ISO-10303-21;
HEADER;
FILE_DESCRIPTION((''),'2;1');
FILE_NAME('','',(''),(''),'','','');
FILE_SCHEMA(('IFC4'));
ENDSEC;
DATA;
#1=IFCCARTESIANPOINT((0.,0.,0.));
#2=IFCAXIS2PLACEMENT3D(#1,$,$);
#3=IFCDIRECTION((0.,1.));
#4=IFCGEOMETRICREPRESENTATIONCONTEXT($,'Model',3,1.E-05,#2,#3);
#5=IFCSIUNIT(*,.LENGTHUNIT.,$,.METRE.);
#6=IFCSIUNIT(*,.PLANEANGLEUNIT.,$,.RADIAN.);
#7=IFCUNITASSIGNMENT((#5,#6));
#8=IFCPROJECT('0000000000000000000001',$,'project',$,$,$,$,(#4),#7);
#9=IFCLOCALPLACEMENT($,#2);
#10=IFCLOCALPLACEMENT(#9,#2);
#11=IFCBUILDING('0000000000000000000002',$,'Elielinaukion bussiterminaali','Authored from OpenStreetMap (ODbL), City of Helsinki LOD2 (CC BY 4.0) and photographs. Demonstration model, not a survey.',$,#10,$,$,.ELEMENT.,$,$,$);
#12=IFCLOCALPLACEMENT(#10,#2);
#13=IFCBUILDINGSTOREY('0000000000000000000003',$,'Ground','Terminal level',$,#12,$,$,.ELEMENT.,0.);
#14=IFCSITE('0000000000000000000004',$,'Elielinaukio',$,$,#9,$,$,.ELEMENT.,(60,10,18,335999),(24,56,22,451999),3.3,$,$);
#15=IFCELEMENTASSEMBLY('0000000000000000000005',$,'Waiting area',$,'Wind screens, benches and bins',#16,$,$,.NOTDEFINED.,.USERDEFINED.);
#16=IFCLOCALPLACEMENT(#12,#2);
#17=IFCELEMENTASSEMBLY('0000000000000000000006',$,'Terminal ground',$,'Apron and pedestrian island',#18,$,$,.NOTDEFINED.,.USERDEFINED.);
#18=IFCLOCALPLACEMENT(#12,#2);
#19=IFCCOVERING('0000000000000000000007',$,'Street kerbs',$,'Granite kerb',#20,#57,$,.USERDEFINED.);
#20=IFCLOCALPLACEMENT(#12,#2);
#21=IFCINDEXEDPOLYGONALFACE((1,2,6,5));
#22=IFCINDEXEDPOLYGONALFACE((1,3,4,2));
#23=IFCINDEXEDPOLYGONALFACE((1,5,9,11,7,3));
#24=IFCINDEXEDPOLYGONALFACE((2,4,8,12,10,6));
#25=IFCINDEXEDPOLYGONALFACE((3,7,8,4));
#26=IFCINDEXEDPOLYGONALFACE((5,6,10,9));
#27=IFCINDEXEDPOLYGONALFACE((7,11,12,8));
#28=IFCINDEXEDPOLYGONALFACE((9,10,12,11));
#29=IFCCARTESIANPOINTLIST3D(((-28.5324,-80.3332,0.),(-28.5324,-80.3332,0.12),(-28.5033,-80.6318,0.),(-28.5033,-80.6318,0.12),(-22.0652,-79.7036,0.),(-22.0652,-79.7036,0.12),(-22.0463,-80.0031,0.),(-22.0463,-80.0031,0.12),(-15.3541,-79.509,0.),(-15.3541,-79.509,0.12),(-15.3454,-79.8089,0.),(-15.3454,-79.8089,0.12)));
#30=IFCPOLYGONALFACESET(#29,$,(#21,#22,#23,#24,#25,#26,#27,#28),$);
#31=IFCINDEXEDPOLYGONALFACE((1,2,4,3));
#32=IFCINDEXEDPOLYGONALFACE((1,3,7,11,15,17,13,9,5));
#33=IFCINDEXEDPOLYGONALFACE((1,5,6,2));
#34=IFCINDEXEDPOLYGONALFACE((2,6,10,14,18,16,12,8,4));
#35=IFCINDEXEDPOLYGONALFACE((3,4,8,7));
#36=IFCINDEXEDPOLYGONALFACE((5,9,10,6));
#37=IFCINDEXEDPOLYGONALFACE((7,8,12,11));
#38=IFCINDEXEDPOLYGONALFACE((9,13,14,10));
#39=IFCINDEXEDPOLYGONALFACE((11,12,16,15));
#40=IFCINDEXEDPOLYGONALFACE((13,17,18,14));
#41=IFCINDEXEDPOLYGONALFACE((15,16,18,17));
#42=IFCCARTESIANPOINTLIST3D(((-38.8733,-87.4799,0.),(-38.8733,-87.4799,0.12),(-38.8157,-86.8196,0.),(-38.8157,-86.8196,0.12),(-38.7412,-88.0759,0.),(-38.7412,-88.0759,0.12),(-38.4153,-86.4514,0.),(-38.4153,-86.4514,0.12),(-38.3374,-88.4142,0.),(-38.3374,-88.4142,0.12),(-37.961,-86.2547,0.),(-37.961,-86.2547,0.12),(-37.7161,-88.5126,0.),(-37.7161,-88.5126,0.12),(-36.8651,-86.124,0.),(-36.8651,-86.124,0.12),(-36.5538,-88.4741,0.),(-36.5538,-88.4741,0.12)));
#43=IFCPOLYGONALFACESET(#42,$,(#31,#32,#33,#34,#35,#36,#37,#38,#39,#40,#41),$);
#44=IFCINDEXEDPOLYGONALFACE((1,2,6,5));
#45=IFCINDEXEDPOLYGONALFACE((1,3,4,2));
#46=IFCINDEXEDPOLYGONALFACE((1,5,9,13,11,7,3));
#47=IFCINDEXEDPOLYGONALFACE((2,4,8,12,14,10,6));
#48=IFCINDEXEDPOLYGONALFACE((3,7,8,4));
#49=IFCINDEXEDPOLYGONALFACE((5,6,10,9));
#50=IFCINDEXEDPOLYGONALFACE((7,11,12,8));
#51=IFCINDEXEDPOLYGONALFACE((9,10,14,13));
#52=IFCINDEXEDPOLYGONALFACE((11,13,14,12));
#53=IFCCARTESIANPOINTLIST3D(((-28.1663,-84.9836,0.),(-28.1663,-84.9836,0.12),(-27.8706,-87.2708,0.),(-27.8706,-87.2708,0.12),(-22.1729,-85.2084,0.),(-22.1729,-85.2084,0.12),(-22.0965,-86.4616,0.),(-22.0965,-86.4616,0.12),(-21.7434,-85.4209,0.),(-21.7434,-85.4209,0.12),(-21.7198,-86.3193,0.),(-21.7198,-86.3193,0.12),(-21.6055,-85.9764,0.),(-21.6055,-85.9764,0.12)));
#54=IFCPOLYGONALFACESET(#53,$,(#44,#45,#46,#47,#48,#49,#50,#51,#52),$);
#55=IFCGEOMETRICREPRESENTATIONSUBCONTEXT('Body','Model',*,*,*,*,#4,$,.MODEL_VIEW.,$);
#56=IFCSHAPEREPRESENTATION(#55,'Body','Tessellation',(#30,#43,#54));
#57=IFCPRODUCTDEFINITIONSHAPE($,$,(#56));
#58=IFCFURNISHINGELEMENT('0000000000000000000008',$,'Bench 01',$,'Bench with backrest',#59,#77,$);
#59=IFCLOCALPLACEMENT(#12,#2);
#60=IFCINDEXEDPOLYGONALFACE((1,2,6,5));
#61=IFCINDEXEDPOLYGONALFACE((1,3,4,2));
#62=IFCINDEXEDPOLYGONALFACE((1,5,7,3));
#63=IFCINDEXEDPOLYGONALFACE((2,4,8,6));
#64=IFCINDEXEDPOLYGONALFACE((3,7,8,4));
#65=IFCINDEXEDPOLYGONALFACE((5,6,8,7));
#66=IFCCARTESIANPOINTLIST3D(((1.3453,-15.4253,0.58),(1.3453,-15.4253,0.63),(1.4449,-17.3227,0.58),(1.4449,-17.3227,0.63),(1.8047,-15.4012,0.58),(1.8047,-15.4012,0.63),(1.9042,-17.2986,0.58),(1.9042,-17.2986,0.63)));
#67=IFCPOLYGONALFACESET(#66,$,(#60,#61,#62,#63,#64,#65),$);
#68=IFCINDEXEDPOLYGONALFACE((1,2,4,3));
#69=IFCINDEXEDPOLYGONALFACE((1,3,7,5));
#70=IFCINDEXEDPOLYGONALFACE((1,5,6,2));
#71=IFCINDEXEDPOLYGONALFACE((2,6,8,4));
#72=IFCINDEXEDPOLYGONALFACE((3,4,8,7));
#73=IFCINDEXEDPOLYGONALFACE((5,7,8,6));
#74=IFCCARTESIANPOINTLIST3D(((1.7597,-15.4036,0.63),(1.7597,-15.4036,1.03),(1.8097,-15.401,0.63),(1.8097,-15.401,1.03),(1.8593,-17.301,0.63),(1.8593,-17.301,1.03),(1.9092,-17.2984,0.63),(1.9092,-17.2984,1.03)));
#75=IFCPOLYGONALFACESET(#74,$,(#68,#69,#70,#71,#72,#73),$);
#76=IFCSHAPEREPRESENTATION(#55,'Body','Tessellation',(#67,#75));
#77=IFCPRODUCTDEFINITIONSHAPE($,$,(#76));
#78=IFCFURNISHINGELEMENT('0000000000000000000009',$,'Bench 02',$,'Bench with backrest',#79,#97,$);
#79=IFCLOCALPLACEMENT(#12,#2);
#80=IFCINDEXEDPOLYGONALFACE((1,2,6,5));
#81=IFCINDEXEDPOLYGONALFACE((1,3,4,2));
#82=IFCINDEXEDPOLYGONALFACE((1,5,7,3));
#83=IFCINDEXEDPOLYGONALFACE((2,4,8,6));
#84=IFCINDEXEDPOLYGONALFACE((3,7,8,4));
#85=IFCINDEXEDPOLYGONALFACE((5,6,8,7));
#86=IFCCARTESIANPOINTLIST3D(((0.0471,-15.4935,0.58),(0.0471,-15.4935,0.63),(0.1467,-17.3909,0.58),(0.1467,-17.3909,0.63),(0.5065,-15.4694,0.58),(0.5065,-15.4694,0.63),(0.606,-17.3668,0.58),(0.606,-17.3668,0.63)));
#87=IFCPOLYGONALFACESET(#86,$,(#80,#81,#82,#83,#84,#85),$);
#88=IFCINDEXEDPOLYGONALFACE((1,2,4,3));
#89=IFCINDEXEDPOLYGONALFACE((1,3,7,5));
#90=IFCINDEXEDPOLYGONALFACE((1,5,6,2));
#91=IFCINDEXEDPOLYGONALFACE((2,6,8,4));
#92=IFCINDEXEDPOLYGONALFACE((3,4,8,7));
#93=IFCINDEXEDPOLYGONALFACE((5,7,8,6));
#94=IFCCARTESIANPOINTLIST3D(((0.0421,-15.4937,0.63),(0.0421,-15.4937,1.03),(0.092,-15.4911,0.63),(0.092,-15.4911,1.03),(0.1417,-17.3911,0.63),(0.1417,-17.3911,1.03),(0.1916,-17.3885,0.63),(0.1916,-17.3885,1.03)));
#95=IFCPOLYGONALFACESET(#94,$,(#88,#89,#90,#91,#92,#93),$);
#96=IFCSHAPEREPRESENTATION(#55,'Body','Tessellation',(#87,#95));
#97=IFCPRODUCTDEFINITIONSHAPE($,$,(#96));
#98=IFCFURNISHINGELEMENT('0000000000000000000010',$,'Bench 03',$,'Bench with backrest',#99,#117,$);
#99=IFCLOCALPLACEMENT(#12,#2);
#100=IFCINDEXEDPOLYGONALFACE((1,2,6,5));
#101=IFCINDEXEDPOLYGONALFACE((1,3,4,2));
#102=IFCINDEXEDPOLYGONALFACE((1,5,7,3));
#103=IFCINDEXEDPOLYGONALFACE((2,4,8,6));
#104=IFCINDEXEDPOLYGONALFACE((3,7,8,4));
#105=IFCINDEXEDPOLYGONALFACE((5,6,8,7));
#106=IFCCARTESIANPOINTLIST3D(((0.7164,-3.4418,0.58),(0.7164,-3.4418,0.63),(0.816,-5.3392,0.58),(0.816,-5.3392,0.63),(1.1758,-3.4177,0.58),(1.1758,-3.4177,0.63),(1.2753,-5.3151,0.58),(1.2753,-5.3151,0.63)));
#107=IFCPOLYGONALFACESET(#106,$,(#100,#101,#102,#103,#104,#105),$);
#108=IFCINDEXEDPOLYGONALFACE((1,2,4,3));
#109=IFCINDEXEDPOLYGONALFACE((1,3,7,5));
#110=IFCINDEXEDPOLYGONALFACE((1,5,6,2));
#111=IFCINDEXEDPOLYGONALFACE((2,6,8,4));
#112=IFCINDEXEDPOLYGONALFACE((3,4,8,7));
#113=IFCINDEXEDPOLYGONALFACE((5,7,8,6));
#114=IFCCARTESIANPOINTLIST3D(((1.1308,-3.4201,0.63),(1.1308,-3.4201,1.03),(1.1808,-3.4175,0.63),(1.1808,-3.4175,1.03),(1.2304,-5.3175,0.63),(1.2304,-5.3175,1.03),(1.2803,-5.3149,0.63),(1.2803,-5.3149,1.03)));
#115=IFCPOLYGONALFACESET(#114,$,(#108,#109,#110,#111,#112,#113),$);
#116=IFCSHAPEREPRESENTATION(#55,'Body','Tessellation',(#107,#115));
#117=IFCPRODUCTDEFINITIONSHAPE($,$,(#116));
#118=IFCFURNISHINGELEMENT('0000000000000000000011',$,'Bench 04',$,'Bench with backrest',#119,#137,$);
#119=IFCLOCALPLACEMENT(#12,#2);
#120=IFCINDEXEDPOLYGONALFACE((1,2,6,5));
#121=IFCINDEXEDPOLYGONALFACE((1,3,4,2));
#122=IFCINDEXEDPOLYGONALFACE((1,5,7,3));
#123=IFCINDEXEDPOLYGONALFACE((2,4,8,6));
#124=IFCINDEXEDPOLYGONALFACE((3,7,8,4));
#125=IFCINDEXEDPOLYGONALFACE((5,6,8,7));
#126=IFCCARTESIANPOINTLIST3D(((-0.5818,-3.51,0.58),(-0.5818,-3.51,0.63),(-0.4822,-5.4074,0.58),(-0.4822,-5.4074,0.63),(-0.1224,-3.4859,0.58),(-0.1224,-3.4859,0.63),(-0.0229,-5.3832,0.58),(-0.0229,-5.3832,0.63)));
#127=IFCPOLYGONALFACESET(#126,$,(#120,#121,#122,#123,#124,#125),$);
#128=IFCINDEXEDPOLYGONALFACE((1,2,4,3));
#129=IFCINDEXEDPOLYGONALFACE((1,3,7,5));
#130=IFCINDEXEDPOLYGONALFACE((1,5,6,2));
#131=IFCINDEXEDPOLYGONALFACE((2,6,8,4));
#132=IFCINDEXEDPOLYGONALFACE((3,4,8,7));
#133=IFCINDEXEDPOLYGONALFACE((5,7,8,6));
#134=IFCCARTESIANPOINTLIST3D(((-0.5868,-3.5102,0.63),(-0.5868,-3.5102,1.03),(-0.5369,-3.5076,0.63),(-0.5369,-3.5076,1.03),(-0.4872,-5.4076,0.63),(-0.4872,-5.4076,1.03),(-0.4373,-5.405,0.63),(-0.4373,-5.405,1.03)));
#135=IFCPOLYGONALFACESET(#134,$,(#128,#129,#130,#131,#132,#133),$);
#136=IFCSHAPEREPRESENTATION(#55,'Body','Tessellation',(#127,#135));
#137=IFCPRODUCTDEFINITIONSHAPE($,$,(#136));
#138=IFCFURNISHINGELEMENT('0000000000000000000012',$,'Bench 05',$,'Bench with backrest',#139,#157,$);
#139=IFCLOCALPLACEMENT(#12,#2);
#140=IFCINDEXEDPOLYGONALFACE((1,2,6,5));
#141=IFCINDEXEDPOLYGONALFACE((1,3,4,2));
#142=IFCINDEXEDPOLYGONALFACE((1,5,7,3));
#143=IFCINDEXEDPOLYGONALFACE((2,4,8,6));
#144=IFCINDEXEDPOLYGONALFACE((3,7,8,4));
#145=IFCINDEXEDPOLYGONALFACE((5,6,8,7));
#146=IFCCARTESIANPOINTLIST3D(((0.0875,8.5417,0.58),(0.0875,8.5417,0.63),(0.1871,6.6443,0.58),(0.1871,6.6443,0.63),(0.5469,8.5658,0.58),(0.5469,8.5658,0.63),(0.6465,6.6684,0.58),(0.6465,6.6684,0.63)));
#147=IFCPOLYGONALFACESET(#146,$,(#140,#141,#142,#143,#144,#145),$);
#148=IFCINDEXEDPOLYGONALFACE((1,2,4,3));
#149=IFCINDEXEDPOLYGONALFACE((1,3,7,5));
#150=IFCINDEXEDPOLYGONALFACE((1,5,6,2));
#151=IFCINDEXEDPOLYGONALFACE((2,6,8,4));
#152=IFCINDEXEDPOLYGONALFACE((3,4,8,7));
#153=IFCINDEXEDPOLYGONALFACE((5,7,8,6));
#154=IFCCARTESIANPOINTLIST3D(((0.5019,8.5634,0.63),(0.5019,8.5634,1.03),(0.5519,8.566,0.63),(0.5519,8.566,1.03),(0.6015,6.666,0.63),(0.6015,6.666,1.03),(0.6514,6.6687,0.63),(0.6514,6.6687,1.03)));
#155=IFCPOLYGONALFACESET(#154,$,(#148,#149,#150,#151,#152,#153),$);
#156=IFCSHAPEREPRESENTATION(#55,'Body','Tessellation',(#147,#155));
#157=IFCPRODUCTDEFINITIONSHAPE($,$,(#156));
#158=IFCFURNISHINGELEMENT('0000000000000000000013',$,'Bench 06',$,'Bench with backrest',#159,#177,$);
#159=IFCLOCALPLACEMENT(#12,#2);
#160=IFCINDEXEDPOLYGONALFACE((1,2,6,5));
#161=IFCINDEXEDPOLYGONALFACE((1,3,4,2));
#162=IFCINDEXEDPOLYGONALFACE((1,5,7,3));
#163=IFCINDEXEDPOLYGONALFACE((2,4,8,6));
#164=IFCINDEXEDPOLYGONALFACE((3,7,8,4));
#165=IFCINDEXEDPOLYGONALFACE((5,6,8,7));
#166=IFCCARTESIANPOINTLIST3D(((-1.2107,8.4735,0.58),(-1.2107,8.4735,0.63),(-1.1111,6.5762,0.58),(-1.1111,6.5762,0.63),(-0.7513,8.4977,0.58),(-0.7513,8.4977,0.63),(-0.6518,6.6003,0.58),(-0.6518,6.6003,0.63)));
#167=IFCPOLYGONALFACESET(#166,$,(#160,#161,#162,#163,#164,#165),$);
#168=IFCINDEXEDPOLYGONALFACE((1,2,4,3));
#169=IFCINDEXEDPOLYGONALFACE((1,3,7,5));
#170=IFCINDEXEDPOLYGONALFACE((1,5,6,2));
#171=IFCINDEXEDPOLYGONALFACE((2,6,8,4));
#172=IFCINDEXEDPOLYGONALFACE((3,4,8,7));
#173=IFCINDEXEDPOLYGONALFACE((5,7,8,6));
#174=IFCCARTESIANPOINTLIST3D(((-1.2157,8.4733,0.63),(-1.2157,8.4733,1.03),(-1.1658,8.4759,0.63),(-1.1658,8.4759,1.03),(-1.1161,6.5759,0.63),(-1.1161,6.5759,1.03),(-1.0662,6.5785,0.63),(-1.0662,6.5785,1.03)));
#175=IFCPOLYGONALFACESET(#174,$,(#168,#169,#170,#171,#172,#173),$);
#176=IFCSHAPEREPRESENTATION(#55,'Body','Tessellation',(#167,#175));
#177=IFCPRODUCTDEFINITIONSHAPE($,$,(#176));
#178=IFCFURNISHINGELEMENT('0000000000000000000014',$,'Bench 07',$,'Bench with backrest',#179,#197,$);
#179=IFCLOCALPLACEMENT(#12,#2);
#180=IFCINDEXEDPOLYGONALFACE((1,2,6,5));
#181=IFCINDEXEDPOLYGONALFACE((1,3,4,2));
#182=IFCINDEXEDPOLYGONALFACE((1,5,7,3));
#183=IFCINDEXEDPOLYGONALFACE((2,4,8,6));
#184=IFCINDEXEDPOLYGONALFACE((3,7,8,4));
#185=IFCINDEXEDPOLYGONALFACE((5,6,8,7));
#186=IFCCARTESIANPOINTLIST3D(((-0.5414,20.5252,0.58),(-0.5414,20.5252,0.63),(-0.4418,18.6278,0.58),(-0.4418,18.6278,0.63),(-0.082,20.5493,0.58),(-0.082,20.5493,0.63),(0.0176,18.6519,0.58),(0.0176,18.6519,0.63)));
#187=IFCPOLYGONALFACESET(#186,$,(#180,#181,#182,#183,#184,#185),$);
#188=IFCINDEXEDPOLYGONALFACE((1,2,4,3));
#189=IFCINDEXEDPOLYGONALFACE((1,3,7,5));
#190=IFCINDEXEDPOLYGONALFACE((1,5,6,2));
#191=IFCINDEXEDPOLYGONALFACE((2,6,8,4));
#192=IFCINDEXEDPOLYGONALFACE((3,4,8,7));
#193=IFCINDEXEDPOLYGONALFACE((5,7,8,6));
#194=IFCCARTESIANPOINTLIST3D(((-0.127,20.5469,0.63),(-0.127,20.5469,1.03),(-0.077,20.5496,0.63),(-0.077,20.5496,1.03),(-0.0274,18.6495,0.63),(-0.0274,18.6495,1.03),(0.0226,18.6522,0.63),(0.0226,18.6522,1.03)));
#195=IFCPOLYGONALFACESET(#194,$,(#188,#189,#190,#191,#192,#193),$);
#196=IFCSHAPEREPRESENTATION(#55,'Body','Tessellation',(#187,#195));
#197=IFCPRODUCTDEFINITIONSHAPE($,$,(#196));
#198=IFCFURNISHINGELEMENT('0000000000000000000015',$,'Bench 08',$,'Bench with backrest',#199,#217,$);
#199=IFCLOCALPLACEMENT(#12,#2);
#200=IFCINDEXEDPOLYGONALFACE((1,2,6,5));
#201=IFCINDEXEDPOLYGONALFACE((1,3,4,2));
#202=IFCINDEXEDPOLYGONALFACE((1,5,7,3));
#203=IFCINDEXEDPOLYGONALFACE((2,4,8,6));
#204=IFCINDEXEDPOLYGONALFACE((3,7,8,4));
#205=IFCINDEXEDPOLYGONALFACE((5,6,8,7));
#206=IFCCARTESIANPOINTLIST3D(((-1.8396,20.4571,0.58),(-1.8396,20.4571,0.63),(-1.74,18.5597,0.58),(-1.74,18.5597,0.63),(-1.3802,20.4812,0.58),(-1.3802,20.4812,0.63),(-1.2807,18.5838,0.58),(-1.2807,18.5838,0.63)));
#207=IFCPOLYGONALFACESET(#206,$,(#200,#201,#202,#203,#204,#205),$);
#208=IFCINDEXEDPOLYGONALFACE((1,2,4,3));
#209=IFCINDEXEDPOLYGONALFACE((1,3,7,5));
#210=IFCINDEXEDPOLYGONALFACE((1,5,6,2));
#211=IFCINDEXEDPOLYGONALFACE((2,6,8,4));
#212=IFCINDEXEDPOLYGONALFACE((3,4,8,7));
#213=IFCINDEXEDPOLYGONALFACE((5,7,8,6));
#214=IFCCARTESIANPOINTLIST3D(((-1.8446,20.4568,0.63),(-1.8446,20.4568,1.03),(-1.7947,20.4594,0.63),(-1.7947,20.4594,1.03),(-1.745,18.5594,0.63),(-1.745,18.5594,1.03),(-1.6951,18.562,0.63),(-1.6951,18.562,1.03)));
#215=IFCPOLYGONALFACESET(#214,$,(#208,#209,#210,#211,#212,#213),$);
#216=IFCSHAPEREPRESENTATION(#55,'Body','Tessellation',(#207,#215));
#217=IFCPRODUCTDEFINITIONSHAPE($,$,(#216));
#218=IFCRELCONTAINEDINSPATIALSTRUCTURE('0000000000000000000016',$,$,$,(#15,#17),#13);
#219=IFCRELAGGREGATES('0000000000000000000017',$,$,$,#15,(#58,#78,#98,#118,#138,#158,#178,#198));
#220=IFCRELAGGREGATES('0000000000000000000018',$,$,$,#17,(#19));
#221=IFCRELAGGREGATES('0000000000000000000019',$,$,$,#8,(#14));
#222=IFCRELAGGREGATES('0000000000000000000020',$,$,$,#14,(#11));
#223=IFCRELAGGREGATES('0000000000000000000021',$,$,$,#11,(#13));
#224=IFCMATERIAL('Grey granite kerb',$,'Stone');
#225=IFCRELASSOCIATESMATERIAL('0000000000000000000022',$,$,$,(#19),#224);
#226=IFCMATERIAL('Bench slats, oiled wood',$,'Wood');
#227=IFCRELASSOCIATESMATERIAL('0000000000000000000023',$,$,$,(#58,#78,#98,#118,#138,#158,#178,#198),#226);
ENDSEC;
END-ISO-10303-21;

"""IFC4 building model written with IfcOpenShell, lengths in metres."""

from ifc_helpers import new_model, si_unit, direction, frame, frame_2d, origin, place, context, subcontext, project, spatial, polyline, rectangle, outline, extrude, material, element, aggregate, save


model = new_model("IFC4")

# Units and contexts
model_context = context("Model", 3, precision=1e-05, world=origin(), true_north=direction((0.0, 1.0)))
body_context = subcontext(model_context, "Body", "Model", "MODEL_VIEW")
ifc_project = project(units=[si_unit("LENGTHUNIT", "METRE"), si_unit("PLANEANGLEUNIT", "RADIAN")], contexts=[model_context])

# Site, building, storey
site_placement = place(None, origin())
site = spatial("IfcSite", under=ifc_project, at=site_placement, Name="Elielinaukio", CompositionType="ELEMENT", RefLatitude=(60, 10, 18, 335999), RefLongitude=(24, 56, 22, 451999), RefElevation=3.3)
building_placement = place(site_placement, origin())
building = spatial("IfcBuilding", under=site, at=building_placement, Name="Elielinaukion bussiterminaali", Description="Authored from OpenStreetMap (ODbL), City of Helsinki LOD2 (CC BY 4.0) and photographs. Demonstration model, not a survey.", CompositionType="ELEMENT")
storey_placement = place(building_placement, origin())
storey = spatial("IfcBuildingStorey", under=building, at=storey_placement, Name="Ground", Description="Terminal level", CompositionType="ELEMENT", Elevation=0.0)

# Element assembly
assembly_1_placement = place(building_placement, origin())
assembly_1 = element("IfcElementAssembly", 1, at=assembly_1_placement, inside=storey, Name="Waiting area", ObjectType="Wind screens, benches and bins", AssemblyPlace="NOTDEFINED", PredefinedType="USERDEFINED")

# Element assembly
assembly_2_placement = place(building_placement, origin())
assembly_2 = element("IfcElementAssembly", 2, at=assembly_2_placement, inside=storey, Name="Terminal ground", ObjectType="Apron and pedestrian island", AssemblyPlace="NOTDEFINED", PredefinedType="USERDEFINED")

# Covering
ifc_material_1 = material(Name="Grey granite kerb", Category="Stone")
covering_1_placement = place(building_placement, origin())
covering_1 = element("IfcCovering", 3, at=covering_1_placement, material=ifc_material_1, Name="Street kerbs", ObjectType="Granite kerb", PredefinedType="USERDEFINED", context=body_context, shape_type="SweptSolid", body=[
    extrude(outline(polyline([(-22.0652, -79.7036), (-15.3541, -79.509), (-15.3454, -79.8089), (-22.0463, -80.0031), (-28.5033, -80.6318), (-28.5324, -80.3332), (-22.0652, -79.7036)])), origin(), (0.0, 0.0, 1.0), 0.12),
    extrude(outline(polyline([(-36.5538, -88.4741), (-37.7161, -88.5126), (-38.3374, -88.4142), (-38.7412, -88.0759), (-38.8733, -87.4799), (-38.8157, -86.8196), (-38.4153, -86.4514), (-37.961, -86.2547), (-36.8651, -86.124), (-36.5538, -88.4741)])), origin(), (0.0, 0.0, 1.0), 0.12),
    extrude(outline(polyline([(-27.8706, -87.2708), (-28.1663, -84.9836), (-22.1729, -85.2084), (-21.7434, -85.4209), (-21.6055, -85.9764), (-21.7198, -86.3193), (-22.0965, -86.4616), (-27.8706, -87.2708)])), origin(), (0.0, 0.0, 1.0), 0.12),
])

# Furnishing elements
ifc_material_2 = material(Name="Bench slats, oiled wood", Category="Wood")
furnishing_1_placement = place(building_placement, origin())
furnishing_1 = element("IfcFurnishingElement", 4, at=furnishing_1_placement, material=ifc_material_2, Name="Bench 01", ObjectType="Bench with backrest", context=body_context, shape_type="SweptSolid", body=[
    extrude(rectangle(XDim=1.9, YDim=0.46, at=frame_2d((0.0, 0.0), x_axis=(-0.052408, 0.998626))), frame((1.6248, -16.362, 0.58)), (0.0, 0.0, 1.0), 0.05),
    extrude(rectangle(XDim=1.9, YDim=0.05, at=frame_2d((0.0, 0.0), x_axis=(-0.052408, 0.998626))), frame((1.8345, -16.351, 0.63)), (0.0, 0.0, 1.0), 0.4),
])
furnishing_2_placement = place(building_placement, origin())
furnishing_2 = element("IfcFurnishingElement", 5, at=furnishing_2_placement, material=ifc_material_2, Name="Bench 02", ObjectType="Bench with backrest", context=body_context, shape_type="SweptSolid", body=[
    extrude(rectangle(XDim=1.9, YDim=0.46, at=frame_2d((0.0, 0.0), x_axis=(-0.052408, 0.998626))), frame((0.3266, -16.4301, 0.58)), (0.0, 0.0, 1.0), 0.05),
    extrude(rectangle(XDim=1.9, YDim=0.05, at=frame_2d((0.0, 0.0), x_axis=(-0.052408, 0.998626))), frame((0.1168, -16.4411, 0.63)), (0.0, 0.0, 1.0), 0.4),
])
furnishing_3_placement = place(building_placement, origin())
furnishing_3 = element("IfcFurnishingElement", 6, at=furnishing_3_placement, material=ifc_material_2, Name="Bench 03", ObjectType="Bench with backrest", context=body_context, shape_type="SweptSolid", body=[
    extrude(rectangle(XDim=1.9, YDim=0.46, at=frame_2d((0.0, 0.0), x_axis=(-0.052408, 0.998626))), frame((0.9959, -4.3785, 0.58)), (0.0, 0.0, 1.0), 0.05),
    extrude(rectangle(XDim=1.9, YDim=0.05, at=frame_2d((0.0, 0.0), x_axis=(-0.052408, 0.998626))), frame((1.2056, -4.3675, 0.63)), (0.0, 0.0, 1.0), 0.4),
])
furnishing_4_placement = place(building_placement, origin())
furnishing_4 = element("IfcFurnishingElement", 7, at=furnishing_4_placement, material=ifc_material_2, Name="Bench 04", ObjectType="Bench with backrest", context=body_context, shape_type="SweptSolid", body=[
    extrude(rectangle(XDim=1.9, YDim=0.46, at=frame_2d((0.0, 0.0), x_axis=(-0.052408, 0.998626))), frame((-0.3023, -4.4466, 0.58)), (0.0, 0.0, 1.0), 0.05),
    extrude(rectangle(XDim=1.9, YDim=0.05, at=frame_2d((0.0, 0.0), x_axis=(-0.052408, 0.998626))), frame((-0.512, -4.4576, 0.63)), (0.0, 0.0, 1.0), 0.4),
])
furnishing_5_placement = place(building_placement, origin())
furnishing_5 = element("IfcFurnishingElement", 8, at=furnishing_5_placement, material=ifc_material_2, Name="Bench 05", ObjectType="Bench with backrest", context=body_context, shape_type="SweptSolid", body=[
    extrude(rectangle(XDim=1.9, YDim=0.46, at=frame_2d((0.0, 0.0), x_axis=(-0.052408, 0.998626))), frame((0.367, 7.605, 0.58)), (0.0, 0.0, 1.0), 0.05),
    extrude(rectangle(XDim=1.9, YDim=0.05, at=frame_2d((0.0, 0.0), x_axis=(-0.052408, 0.998626))), frame((0.5767, 7.616, 0.63)), (0.0, 0.0, 1.0), 0.4),
])
furnishing_6_placement = place(building_placement, origin())
furnishing_6 = element("IfcFurnishingElement", 9, at=furnishing_6_placement, material=ifc_material_2, Name="Bench 06", ObjectType="Bench with backrest", context=body_context, shape_type="SweptSolid", body=[
    extrude(rectangle(XDim=1.9, YDim=0.46, at=frame_2d((0.0, 0.0), x_axis=(-0.052408, 0.998626))), frame((-0.9312, 7.5369, 0.58)), (0.0, 0.0, 1.0), 0.05),
    extrude(rectangle(XDim=1.9, YDim=0.05, at=frame_2d((0.0, 0.0), x_axis=(-0.052408, 0.998626))), frame((-1.1409, 7.5259, 0.63)), (0.0, 0.0, 1.0), 0.4),
])
furnishing_7_placement = place(building_placement, origin())
furnishing_7 = element("IfcFurnishingElement", 10, at=furnishing_7_placement, material=ifc_material_2, Name="Bench 07", ObjectType="Bench with backrest", context=body_context, shape_type="SweptSolid", body=[
    extrude(rectangle(XDim=1.9, YDim=0.46, at=frame_2d((0.0, 0.0), x_axis=(-0.052408, 0.998626))), frame((-0.2619, 19.5885, 0.58)), (0.0, 0.0, 1.0), 0.05),
    extrude(rectangle(XDim=1.9, YDim=0.05, at=frame_2d((0.0, 0.0), x_axis=(-0.052408, 0.998626))), frame((-0.0522, 19.5995, 0.63)), (0.0, 0.0, 1.0), 0.4),
])
furnishing_8_placement = place(building_placement, origin())
furnishing_8 = element("IfcFurnishingElement", 11, at=furnishing_8_placement, material=ifc_material_2, Name="Bench 08", ObjectType="Bench with backrest", context=body_context, shape_type="SweptSolid", body=[
    extrude(rectangle(XDim=1.9, YDim=0.46, at=frame_2d((0.0, 0.0), x_axis=(-0.052408, 0.998626))), frame((-1.5601, 19.5204, 0.58)), (0.0, 0.0, 1.0), 0.05),
    extrude(rectangle(XDim=1.9, YDim=0.05, at=frame_2d((0.0, 0.0), x_axis=(-0.052408, 0.998626))), frame((-1.7698, 19.5094, 0.63)), (0.0, 0.0, 1.0), 0.4),
])
aggregate(assembly_1, [furnishing_1, furnishing_2, furnishing_3, furnishing_4, furnishing_5, furnishing_6, furnishing_7, furnishing_8])

aggregate(assembly_2, [covering_1])

save(model, "model.ifc")
